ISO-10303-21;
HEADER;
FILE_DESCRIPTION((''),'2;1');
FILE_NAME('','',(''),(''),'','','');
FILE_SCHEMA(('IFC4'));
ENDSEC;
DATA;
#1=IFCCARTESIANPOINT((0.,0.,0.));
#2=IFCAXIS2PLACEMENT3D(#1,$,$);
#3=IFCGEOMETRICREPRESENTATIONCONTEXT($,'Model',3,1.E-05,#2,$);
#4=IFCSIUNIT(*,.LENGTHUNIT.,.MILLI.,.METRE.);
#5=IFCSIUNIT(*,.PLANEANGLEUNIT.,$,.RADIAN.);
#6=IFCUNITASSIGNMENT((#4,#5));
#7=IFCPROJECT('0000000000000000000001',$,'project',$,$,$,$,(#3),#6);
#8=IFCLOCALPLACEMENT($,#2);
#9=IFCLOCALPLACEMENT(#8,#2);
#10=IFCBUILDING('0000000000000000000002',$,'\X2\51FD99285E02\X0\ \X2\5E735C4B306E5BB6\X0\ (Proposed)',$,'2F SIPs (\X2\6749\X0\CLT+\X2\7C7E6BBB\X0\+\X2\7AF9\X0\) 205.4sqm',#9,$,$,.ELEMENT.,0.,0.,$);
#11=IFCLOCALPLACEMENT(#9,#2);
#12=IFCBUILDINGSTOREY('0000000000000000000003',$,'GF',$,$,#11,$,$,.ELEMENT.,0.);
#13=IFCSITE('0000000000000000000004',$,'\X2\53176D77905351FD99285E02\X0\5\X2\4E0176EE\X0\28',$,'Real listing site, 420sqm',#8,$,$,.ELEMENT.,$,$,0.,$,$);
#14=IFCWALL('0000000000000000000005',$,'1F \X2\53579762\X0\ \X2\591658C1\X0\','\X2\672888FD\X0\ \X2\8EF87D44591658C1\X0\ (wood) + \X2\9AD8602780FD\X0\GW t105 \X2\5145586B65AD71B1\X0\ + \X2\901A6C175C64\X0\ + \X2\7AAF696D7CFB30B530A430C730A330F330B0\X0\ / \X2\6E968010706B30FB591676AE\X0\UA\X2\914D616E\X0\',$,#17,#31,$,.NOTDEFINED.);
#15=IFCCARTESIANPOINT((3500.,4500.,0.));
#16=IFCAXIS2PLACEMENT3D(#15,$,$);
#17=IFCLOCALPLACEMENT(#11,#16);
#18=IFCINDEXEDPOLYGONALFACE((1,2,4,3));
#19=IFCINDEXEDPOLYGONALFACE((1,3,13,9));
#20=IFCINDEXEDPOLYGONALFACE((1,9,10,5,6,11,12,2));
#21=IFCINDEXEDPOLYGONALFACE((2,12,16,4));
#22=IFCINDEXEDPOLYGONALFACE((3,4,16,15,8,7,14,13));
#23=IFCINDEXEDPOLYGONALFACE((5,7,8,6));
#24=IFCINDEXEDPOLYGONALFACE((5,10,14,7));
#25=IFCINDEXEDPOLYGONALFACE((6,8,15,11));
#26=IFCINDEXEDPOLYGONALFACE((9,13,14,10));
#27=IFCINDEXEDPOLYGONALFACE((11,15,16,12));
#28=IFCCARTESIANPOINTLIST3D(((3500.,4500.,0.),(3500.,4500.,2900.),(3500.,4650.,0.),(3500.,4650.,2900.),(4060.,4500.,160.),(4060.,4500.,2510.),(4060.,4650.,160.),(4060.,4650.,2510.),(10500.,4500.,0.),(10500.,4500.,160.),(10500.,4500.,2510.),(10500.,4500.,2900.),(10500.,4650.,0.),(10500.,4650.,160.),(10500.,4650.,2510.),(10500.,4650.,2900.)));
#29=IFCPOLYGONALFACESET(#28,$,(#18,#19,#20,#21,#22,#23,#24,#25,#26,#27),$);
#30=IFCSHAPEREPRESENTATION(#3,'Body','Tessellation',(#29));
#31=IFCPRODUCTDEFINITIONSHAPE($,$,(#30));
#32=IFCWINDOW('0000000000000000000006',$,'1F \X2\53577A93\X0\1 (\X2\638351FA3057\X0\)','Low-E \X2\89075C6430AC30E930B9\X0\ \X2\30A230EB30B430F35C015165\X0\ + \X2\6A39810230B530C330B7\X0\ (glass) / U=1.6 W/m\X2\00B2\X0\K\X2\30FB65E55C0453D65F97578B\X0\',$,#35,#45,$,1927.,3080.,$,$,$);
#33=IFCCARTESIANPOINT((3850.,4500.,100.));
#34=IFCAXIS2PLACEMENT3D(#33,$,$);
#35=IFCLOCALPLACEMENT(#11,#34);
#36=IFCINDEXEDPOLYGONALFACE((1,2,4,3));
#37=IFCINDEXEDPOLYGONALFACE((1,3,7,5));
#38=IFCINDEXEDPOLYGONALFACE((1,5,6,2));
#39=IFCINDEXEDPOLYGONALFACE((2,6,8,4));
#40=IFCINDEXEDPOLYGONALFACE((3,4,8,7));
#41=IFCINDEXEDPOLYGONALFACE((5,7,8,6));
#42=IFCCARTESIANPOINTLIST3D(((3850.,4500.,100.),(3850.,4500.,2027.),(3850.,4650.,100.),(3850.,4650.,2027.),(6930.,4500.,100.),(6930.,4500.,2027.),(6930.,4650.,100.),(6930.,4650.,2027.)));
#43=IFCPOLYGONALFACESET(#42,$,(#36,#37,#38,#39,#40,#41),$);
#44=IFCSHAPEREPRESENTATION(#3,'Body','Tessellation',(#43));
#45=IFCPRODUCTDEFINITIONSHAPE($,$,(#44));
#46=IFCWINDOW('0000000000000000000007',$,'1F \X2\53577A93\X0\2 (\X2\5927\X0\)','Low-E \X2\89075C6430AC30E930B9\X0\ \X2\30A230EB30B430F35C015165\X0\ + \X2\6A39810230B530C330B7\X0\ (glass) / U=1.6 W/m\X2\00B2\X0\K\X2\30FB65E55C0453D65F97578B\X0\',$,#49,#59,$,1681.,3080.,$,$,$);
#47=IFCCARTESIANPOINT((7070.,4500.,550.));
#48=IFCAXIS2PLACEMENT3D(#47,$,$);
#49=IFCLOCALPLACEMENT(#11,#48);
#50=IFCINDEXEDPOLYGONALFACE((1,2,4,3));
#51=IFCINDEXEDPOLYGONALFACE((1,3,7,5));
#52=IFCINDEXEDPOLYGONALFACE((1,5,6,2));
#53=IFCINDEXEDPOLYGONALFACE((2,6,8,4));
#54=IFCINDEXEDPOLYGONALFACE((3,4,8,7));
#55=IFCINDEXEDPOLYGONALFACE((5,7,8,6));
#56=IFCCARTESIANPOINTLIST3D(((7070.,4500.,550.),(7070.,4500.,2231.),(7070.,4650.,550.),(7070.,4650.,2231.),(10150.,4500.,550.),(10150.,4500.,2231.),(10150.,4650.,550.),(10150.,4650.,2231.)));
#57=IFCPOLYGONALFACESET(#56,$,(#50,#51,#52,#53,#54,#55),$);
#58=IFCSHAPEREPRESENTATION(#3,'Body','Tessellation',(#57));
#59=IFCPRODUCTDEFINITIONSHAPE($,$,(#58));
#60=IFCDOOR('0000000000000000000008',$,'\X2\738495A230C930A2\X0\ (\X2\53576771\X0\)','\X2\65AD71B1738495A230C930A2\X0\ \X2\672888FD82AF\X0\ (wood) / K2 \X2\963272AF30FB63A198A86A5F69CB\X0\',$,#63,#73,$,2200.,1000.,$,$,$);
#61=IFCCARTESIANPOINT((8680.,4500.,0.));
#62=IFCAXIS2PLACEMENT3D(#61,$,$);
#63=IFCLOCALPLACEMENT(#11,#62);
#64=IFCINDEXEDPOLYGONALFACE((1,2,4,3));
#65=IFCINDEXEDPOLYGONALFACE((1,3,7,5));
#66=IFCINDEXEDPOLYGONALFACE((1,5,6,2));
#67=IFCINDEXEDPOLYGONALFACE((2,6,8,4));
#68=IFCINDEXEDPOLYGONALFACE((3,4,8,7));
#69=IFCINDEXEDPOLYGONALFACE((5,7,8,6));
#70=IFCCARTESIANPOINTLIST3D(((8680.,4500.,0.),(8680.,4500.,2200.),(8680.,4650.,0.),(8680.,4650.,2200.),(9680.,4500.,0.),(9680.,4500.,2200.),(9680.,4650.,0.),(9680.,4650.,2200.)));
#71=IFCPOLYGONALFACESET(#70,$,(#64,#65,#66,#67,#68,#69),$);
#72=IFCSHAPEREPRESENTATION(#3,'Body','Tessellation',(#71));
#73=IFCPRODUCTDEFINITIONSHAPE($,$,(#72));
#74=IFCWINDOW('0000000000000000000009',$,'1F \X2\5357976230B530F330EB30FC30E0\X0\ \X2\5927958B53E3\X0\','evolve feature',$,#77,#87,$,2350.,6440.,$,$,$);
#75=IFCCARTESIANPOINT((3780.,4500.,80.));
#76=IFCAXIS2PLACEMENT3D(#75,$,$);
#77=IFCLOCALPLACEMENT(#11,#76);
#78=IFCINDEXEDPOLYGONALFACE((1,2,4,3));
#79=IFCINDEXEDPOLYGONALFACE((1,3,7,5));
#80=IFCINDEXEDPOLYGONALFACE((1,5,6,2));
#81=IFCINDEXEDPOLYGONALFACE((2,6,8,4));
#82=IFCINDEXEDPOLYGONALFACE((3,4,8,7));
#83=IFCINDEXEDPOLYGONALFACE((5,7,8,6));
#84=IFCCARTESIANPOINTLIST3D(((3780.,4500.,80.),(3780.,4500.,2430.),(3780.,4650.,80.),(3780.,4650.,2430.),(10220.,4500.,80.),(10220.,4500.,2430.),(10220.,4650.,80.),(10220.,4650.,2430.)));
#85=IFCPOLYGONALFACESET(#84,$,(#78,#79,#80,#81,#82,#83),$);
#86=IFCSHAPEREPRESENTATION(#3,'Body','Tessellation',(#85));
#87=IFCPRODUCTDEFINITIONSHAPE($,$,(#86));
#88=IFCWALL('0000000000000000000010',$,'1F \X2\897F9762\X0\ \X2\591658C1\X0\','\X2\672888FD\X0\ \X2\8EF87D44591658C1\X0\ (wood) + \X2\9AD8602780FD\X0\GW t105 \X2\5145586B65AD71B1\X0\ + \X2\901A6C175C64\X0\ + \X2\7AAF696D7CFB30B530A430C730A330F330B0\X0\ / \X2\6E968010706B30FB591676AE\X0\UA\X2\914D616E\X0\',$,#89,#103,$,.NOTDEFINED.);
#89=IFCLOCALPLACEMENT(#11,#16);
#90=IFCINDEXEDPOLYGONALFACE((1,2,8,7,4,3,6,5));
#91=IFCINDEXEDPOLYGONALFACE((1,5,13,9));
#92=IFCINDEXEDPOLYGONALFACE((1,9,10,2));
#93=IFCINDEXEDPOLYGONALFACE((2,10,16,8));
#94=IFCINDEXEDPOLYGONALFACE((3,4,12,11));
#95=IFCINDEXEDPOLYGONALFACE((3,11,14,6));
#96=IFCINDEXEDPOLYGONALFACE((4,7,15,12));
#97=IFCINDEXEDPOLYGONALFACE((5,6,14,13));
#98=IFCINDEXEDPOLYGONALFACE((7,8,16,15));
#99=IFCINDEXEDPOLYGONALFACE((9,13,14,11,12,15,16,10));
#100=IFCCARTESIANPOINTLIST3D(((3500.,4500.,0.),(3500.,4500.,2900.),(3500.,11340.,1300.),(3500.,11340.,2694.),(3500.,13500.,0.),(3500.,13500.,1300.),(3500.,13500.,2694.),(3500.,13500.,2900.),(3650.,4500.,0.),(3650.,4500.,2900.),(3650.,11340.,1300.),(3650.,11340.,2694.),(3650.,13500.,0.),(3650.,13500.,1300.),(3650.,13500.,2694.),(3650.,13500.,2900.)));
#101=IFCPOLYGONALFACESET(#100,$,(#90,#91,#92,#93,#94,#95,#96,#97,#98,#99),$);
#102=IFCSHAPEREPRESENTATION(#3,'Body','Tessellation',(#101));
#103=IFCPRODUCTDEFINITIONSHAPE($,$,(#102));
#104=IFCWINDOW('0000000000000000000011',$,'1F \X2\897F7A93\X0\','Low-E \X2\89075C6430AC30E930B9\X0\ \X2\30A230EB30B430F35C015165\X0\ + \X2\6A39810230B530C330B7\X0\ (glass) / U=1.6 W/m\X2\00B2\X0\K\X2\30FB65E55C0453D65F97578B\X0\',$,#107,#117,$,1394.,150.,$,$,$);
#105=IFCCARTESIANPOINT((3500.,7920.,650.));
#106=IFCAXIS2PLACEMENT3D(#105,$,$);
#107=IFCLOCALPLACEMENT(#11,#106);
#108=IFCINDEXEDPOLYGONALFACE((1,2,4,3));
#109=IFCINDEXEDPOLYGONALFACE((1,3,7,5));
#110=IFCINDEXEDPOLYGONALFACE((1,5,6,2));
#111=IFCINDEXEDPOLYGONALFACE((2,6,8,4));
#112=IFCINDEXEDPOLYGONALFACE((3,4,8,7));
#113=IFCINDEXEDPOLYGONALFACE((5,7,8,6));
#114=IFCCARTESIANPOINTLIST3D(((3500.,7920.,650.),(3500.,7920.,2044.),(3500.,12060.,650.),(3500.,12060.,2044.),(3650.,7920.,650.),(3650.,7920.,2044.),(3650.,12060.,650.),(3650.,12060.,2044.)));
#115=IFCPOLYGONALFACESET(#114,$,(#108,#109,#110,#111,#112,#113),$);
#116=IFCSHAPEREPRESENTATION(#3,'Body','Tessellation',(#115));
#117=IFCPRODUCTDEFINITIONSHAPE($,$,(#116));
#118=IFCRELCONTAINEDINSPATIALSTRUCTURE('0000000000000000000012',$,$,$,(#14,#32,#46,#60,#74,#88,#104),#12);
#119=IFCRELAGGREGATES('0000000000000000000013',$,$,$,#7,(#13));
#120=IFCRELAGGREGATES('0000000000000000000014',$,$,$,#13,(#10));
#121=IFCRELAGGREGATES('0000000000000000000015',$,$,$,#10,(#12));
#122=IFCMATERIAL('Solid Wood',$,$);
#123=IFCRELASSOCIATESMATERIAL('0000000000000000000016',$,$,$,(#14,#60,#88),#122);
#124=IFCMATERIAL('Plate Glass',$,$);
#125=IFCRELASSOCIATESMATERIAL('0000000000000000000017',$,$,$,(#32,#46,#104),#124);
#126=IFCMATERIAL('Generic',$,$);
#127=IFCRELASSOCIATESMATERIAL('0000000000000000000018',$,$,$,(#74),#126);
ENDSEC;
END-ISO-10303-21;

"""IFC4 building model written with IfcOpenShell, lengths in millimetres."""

from ifc_helpers import new_model, si_unit, frame, frame_2d, origin, place, context, project, spatial, rectangle, extrude, material, element, fill, save


model = new_model("IFC4")

# Units and contexts
model_context = context("Model", 3, precision=1e-05, world=origin())
ifc_project = project(units=[si_unit("LENGTHUNIT", "METRE", prefix="MILLI"), si_unit("PLANEANGLEUNIT", "RADIAN")], contexts=[model_context])

# Site, building, storey
site_placement = place(None, origin())
site = spatial("IfcSite", under=ifc_project, at=site_placement, Name="北海道函館市5丁目28", ObjectType="Real listing site, 420sqm", CompositionType="ELEMENT", RefElevation=0.0)
building_placement = place(site_placement, origin())
building = spatial("IfcBuilding", under=site, at=building_placement, Name="函館市 平屋の家 (Proposed)", ObjectType="2F SIPs (杉CLT+籾殻+竹) 205.4sqm", CompositionType="ELEMENT", ElevationOfRefHeight=0.0, ElevationOfTerrain=0.0)
storey_placement = place(building_placement, origin())
storey = spatial("IfcBuildingStorey", under=building, at=storey_placement, Name="GF", CompositionType="ELEMENT", Elevation=0.0)

# Shared definitions
ifc_material_1 = material(Name="Solid Wood")
ifc_material_2 = material(Name="Generic")

# Wall, openings, windows, door
wall_1_placement = place(storey_placement, frame((3500.0, 4500.0, 0.0)))
wall_1 = element("IfcWall", 1, at=wall_1_placement, inside=storey, material=ifc_material_1, Name="1F 南面 外壁", Description="木製 軸組外壁 (wood) + 高性能GW t105 充填断熱 + 通気層 + 窯業系サイディング / 準耐火・外皮UA配慮", PredefinedType="NOTDEFINED", context=model_context, shape_type="SweptSolid", body=[
    extrude(rectangle(XDim=7000.0, YDim=150.0, at=frame_2d((3500.0, 75.0))), frame((3500.0, 4500.0, 0.0)), (0.0, 0.0, 1.0), 2900.0),
])
opening_1_placement = place(storey_placement, frame((3850.0, 4500.0, 100.0)))
opening_1 = element("IfcOpeningElement", 2, at=opening_1_placement, cuts=wall_1, PredefinedType="NOTDEFINED", context=model_context, shape_type="SweptSolid", body=[
    extrude(rectangle(XDim=3080.0, YDim=150.0, at=frame_2d((1540.0, 75.0))), frame((3850.0, 4500.0, 100.0)), (0.0, 0.0, 1.0), 1927.0),
])
opening_2_placement = place(storey_placement, frame((7070.0, 4500.0, 550.0)))
opening_2 = element("IfcOpeningElement", 3, at=opening_2_placement, cuts=wall_1, PredefinedType="NOTDEFINED", context=model_context, shape_type="SweptSolid", body=[
    extrude(rectangle(XDim=3080.0, YDim=150.0, at=frame_2d((1540.0, 75.0))), frame((7070.0, 4500.0, 550.0)), (0.0, 0.0, 1.0), 1681.0),
])
opening_3_placement = place(storey_placement, frame((8680.0, 4500.0, 0.0)))
opening_3 = element("IfcOpeningElement", 4, at=opening_3_placement, cuts=wall_1, PredefinedType="NOTDEFINED", context=model_context, shape_type="SweptSolid", body=[
    extrude(rectangle(XDim=1000.0, YDim=150.0, at=frame_2d((500.0, 75.0))), frame((8680.0, 4500.0, 0.0)), (0.0, 0.0, 1.0), 2200.0),
])
opening_4_placement = place(storey_placement, frame((3780.0, 4500.0, 80.0)))
opening_4 = element("IfcOpeningElement", 5, at=opening_4_placement, cuts=wall_1, PredefinedType="NOTDEFINED", context=model_context, shape_type="SweptSolid", body=[
    extrude(rectangle(XDim=6440.0, YDim=150.0, at=frame_2d((3220.0, 75.0))), frame((3780.0, 4500.0, 80.0)), (0.0, 0.0, 1.0), 2350.0),
])
ifc_material_3 = material(Name="Plate Glass")
window_1_placement = place(storey_placement, frame((3850.0, 4500.0, 100.0)))
window_1 = element("IfcWindow", 6, at=window_1_placement, inside=storey, material=ifc_material_3, Name="1F 南窓1 (掃出し)", Description="Low-E 複層ガラス アルゴン封入 + 樹脂サッシ (glass) / U=1.6 W/m²K・日射取得型", OverallHeight=1927.0, OverallWidth=3080.0, context=model_context, shape_type="SweptSolid", body=[
    extrude(rectangle(XDim=3080.0, YDim=150.0, at=frame_2d((1540.0, 75.0))), frame((3850.0, 4500.0, 100.0)), (0.0, 0.0, 1.0), 1927.0),
])
fill(opening_1, window_1)
window_2_placement = place(storey_placement, frame((7070.0, 4500.0, 550.0)))
window_2 = element("IfcWindow", 7, at=window_2_placement, inside=storey, material=ifc_material_3, Name="1F 南窓2 (大)", Description="Low-E 複層ガラス アルゴン封入 + 樹脂サッシ (glass) / U=1.6 W/m²K・日射取得型", OverallHeight=1681.0, OverallWidth=3080.0, context=model_context, shape_type="SweptSolid", body=[
    extrude(rectangle(XDim=3080.0, YDim=150.0, at=frame_2d((1540.0, 75.0))), frame((7070.0, 4500.0, 550.0)), (0.0, 0.0, 1.0), 1681.0),
])
fill(opening_2, window_2)
door_placement = place(storey_placement, frame((8680.0, 4500.0, 0.0)))
door = element("IfcDoor", 8, at=door_placement, inside=storey, material=ifc_material_1, Name="玄関ドア (南東)", Description="断熱玄関ドア 木製芯 (wood) / K2 防犯・採風機構", OverallHeight=2200.0, OverallWidth=1000.0, context=model_context, shape_type="SweptSolid", body=[
    extrude(rectangle(XDim=1000.0, YDim=150.0, at=frame_2d((500.0, 75.0))), frame((8680.0, 4500.0, 0.0)), (0.0, 0.0, 1.0), 2200.0),
])
fill(opening_3, door)
window_3_placement = place(storey_placement, frame((3780.0, 4500.0, 80.0)))
window_3 = element("IfcWindow", 9, at=window_3_placement, inside=storey, material=ifc_material_2, Name="1F 南面サンルーム 大開口", Description="evolve feature", OverallHeight=2350.0, OverallWidth=6440.0, context=model_context, shape_type="SweptSolid", body=[
    extrude(rectangle(XDim=6440.0, YDim=150.0, at=frame_2d((3220.0, 75.0))), frame((3780.0, 4500.0, 80.0)), (0.0, 0.0, 1.0), 2350.0),
])
fill(opening_4, window_3)

# Wall, opening, window
wall_2_placement = place(storey_placement, frame((3500.0, 4500.0, 0.0)))
wall_2 = element("IfcWall", 10, at=wall_2_placement, inside=storey, material=ifc_material_1, Name="1F 西面 外壁", Description="木製 軸組外壁 (wood) + 高性能GW t105 充填断熱 + 通気層 + 窯業系サイディング / 準耐火・外皮UA配慮", PredefinedType="NOTDEFINED", context=model_context, shape_type="SweptSolid", body=[
    extrude(rectangle(XDim=150.0, YDim=9000.0, at=frame_2d((75.0, 4500.0))), frame((3500.0, 4500.0, 0.0)), (0.0, 0.0, 1.0), 2900.0),
])
opening_5_placement = place(storey_placement, frame((3500.0, 7920.0, 650.0)))
opening_5 = element("IfcOpeningElement", 11, at=opening_5_placement, cuts=wall_2, PredefinedType="NOTDEFINED", context=model_context, shape_type="SweptSolid", body=[
    extrude(rectangle(XDim=150.0, YDim=4140.0, at=frame_2d((75.0, 2070.0))), frame((3500.0, 7920.0, 650.0)), (0.0, 0.0, 1.0), 1394.0),
])
window_4_placement = place(storey_placement, frame((3500.0, 7920.0, 650.0)))
window_4 = element("IfcWindow", 12, at=window_4_placement, inside=storey, material=ifc_material_3, Name="1F 西窓", Description="Low-E 複層ガラス アルゴン封入 + 樹脂サッシ (glass) / U=1.6 W/m²K・日射取得型", OverallHeight=1394.0, OverallWidth=150.0, context=model_context, shape_type="SweptSolid", body=[
    extrude(rectangle(XDim=150.0, YDim=4140.0, at=frame_2d((75.0, 2070.0))), frame((3500.0, 7920.0, 650.0)), (0.0, 0.0, 1.0), 1394.0),
])
fill(opening_5, window_4)

save(model, "model.ifc")
